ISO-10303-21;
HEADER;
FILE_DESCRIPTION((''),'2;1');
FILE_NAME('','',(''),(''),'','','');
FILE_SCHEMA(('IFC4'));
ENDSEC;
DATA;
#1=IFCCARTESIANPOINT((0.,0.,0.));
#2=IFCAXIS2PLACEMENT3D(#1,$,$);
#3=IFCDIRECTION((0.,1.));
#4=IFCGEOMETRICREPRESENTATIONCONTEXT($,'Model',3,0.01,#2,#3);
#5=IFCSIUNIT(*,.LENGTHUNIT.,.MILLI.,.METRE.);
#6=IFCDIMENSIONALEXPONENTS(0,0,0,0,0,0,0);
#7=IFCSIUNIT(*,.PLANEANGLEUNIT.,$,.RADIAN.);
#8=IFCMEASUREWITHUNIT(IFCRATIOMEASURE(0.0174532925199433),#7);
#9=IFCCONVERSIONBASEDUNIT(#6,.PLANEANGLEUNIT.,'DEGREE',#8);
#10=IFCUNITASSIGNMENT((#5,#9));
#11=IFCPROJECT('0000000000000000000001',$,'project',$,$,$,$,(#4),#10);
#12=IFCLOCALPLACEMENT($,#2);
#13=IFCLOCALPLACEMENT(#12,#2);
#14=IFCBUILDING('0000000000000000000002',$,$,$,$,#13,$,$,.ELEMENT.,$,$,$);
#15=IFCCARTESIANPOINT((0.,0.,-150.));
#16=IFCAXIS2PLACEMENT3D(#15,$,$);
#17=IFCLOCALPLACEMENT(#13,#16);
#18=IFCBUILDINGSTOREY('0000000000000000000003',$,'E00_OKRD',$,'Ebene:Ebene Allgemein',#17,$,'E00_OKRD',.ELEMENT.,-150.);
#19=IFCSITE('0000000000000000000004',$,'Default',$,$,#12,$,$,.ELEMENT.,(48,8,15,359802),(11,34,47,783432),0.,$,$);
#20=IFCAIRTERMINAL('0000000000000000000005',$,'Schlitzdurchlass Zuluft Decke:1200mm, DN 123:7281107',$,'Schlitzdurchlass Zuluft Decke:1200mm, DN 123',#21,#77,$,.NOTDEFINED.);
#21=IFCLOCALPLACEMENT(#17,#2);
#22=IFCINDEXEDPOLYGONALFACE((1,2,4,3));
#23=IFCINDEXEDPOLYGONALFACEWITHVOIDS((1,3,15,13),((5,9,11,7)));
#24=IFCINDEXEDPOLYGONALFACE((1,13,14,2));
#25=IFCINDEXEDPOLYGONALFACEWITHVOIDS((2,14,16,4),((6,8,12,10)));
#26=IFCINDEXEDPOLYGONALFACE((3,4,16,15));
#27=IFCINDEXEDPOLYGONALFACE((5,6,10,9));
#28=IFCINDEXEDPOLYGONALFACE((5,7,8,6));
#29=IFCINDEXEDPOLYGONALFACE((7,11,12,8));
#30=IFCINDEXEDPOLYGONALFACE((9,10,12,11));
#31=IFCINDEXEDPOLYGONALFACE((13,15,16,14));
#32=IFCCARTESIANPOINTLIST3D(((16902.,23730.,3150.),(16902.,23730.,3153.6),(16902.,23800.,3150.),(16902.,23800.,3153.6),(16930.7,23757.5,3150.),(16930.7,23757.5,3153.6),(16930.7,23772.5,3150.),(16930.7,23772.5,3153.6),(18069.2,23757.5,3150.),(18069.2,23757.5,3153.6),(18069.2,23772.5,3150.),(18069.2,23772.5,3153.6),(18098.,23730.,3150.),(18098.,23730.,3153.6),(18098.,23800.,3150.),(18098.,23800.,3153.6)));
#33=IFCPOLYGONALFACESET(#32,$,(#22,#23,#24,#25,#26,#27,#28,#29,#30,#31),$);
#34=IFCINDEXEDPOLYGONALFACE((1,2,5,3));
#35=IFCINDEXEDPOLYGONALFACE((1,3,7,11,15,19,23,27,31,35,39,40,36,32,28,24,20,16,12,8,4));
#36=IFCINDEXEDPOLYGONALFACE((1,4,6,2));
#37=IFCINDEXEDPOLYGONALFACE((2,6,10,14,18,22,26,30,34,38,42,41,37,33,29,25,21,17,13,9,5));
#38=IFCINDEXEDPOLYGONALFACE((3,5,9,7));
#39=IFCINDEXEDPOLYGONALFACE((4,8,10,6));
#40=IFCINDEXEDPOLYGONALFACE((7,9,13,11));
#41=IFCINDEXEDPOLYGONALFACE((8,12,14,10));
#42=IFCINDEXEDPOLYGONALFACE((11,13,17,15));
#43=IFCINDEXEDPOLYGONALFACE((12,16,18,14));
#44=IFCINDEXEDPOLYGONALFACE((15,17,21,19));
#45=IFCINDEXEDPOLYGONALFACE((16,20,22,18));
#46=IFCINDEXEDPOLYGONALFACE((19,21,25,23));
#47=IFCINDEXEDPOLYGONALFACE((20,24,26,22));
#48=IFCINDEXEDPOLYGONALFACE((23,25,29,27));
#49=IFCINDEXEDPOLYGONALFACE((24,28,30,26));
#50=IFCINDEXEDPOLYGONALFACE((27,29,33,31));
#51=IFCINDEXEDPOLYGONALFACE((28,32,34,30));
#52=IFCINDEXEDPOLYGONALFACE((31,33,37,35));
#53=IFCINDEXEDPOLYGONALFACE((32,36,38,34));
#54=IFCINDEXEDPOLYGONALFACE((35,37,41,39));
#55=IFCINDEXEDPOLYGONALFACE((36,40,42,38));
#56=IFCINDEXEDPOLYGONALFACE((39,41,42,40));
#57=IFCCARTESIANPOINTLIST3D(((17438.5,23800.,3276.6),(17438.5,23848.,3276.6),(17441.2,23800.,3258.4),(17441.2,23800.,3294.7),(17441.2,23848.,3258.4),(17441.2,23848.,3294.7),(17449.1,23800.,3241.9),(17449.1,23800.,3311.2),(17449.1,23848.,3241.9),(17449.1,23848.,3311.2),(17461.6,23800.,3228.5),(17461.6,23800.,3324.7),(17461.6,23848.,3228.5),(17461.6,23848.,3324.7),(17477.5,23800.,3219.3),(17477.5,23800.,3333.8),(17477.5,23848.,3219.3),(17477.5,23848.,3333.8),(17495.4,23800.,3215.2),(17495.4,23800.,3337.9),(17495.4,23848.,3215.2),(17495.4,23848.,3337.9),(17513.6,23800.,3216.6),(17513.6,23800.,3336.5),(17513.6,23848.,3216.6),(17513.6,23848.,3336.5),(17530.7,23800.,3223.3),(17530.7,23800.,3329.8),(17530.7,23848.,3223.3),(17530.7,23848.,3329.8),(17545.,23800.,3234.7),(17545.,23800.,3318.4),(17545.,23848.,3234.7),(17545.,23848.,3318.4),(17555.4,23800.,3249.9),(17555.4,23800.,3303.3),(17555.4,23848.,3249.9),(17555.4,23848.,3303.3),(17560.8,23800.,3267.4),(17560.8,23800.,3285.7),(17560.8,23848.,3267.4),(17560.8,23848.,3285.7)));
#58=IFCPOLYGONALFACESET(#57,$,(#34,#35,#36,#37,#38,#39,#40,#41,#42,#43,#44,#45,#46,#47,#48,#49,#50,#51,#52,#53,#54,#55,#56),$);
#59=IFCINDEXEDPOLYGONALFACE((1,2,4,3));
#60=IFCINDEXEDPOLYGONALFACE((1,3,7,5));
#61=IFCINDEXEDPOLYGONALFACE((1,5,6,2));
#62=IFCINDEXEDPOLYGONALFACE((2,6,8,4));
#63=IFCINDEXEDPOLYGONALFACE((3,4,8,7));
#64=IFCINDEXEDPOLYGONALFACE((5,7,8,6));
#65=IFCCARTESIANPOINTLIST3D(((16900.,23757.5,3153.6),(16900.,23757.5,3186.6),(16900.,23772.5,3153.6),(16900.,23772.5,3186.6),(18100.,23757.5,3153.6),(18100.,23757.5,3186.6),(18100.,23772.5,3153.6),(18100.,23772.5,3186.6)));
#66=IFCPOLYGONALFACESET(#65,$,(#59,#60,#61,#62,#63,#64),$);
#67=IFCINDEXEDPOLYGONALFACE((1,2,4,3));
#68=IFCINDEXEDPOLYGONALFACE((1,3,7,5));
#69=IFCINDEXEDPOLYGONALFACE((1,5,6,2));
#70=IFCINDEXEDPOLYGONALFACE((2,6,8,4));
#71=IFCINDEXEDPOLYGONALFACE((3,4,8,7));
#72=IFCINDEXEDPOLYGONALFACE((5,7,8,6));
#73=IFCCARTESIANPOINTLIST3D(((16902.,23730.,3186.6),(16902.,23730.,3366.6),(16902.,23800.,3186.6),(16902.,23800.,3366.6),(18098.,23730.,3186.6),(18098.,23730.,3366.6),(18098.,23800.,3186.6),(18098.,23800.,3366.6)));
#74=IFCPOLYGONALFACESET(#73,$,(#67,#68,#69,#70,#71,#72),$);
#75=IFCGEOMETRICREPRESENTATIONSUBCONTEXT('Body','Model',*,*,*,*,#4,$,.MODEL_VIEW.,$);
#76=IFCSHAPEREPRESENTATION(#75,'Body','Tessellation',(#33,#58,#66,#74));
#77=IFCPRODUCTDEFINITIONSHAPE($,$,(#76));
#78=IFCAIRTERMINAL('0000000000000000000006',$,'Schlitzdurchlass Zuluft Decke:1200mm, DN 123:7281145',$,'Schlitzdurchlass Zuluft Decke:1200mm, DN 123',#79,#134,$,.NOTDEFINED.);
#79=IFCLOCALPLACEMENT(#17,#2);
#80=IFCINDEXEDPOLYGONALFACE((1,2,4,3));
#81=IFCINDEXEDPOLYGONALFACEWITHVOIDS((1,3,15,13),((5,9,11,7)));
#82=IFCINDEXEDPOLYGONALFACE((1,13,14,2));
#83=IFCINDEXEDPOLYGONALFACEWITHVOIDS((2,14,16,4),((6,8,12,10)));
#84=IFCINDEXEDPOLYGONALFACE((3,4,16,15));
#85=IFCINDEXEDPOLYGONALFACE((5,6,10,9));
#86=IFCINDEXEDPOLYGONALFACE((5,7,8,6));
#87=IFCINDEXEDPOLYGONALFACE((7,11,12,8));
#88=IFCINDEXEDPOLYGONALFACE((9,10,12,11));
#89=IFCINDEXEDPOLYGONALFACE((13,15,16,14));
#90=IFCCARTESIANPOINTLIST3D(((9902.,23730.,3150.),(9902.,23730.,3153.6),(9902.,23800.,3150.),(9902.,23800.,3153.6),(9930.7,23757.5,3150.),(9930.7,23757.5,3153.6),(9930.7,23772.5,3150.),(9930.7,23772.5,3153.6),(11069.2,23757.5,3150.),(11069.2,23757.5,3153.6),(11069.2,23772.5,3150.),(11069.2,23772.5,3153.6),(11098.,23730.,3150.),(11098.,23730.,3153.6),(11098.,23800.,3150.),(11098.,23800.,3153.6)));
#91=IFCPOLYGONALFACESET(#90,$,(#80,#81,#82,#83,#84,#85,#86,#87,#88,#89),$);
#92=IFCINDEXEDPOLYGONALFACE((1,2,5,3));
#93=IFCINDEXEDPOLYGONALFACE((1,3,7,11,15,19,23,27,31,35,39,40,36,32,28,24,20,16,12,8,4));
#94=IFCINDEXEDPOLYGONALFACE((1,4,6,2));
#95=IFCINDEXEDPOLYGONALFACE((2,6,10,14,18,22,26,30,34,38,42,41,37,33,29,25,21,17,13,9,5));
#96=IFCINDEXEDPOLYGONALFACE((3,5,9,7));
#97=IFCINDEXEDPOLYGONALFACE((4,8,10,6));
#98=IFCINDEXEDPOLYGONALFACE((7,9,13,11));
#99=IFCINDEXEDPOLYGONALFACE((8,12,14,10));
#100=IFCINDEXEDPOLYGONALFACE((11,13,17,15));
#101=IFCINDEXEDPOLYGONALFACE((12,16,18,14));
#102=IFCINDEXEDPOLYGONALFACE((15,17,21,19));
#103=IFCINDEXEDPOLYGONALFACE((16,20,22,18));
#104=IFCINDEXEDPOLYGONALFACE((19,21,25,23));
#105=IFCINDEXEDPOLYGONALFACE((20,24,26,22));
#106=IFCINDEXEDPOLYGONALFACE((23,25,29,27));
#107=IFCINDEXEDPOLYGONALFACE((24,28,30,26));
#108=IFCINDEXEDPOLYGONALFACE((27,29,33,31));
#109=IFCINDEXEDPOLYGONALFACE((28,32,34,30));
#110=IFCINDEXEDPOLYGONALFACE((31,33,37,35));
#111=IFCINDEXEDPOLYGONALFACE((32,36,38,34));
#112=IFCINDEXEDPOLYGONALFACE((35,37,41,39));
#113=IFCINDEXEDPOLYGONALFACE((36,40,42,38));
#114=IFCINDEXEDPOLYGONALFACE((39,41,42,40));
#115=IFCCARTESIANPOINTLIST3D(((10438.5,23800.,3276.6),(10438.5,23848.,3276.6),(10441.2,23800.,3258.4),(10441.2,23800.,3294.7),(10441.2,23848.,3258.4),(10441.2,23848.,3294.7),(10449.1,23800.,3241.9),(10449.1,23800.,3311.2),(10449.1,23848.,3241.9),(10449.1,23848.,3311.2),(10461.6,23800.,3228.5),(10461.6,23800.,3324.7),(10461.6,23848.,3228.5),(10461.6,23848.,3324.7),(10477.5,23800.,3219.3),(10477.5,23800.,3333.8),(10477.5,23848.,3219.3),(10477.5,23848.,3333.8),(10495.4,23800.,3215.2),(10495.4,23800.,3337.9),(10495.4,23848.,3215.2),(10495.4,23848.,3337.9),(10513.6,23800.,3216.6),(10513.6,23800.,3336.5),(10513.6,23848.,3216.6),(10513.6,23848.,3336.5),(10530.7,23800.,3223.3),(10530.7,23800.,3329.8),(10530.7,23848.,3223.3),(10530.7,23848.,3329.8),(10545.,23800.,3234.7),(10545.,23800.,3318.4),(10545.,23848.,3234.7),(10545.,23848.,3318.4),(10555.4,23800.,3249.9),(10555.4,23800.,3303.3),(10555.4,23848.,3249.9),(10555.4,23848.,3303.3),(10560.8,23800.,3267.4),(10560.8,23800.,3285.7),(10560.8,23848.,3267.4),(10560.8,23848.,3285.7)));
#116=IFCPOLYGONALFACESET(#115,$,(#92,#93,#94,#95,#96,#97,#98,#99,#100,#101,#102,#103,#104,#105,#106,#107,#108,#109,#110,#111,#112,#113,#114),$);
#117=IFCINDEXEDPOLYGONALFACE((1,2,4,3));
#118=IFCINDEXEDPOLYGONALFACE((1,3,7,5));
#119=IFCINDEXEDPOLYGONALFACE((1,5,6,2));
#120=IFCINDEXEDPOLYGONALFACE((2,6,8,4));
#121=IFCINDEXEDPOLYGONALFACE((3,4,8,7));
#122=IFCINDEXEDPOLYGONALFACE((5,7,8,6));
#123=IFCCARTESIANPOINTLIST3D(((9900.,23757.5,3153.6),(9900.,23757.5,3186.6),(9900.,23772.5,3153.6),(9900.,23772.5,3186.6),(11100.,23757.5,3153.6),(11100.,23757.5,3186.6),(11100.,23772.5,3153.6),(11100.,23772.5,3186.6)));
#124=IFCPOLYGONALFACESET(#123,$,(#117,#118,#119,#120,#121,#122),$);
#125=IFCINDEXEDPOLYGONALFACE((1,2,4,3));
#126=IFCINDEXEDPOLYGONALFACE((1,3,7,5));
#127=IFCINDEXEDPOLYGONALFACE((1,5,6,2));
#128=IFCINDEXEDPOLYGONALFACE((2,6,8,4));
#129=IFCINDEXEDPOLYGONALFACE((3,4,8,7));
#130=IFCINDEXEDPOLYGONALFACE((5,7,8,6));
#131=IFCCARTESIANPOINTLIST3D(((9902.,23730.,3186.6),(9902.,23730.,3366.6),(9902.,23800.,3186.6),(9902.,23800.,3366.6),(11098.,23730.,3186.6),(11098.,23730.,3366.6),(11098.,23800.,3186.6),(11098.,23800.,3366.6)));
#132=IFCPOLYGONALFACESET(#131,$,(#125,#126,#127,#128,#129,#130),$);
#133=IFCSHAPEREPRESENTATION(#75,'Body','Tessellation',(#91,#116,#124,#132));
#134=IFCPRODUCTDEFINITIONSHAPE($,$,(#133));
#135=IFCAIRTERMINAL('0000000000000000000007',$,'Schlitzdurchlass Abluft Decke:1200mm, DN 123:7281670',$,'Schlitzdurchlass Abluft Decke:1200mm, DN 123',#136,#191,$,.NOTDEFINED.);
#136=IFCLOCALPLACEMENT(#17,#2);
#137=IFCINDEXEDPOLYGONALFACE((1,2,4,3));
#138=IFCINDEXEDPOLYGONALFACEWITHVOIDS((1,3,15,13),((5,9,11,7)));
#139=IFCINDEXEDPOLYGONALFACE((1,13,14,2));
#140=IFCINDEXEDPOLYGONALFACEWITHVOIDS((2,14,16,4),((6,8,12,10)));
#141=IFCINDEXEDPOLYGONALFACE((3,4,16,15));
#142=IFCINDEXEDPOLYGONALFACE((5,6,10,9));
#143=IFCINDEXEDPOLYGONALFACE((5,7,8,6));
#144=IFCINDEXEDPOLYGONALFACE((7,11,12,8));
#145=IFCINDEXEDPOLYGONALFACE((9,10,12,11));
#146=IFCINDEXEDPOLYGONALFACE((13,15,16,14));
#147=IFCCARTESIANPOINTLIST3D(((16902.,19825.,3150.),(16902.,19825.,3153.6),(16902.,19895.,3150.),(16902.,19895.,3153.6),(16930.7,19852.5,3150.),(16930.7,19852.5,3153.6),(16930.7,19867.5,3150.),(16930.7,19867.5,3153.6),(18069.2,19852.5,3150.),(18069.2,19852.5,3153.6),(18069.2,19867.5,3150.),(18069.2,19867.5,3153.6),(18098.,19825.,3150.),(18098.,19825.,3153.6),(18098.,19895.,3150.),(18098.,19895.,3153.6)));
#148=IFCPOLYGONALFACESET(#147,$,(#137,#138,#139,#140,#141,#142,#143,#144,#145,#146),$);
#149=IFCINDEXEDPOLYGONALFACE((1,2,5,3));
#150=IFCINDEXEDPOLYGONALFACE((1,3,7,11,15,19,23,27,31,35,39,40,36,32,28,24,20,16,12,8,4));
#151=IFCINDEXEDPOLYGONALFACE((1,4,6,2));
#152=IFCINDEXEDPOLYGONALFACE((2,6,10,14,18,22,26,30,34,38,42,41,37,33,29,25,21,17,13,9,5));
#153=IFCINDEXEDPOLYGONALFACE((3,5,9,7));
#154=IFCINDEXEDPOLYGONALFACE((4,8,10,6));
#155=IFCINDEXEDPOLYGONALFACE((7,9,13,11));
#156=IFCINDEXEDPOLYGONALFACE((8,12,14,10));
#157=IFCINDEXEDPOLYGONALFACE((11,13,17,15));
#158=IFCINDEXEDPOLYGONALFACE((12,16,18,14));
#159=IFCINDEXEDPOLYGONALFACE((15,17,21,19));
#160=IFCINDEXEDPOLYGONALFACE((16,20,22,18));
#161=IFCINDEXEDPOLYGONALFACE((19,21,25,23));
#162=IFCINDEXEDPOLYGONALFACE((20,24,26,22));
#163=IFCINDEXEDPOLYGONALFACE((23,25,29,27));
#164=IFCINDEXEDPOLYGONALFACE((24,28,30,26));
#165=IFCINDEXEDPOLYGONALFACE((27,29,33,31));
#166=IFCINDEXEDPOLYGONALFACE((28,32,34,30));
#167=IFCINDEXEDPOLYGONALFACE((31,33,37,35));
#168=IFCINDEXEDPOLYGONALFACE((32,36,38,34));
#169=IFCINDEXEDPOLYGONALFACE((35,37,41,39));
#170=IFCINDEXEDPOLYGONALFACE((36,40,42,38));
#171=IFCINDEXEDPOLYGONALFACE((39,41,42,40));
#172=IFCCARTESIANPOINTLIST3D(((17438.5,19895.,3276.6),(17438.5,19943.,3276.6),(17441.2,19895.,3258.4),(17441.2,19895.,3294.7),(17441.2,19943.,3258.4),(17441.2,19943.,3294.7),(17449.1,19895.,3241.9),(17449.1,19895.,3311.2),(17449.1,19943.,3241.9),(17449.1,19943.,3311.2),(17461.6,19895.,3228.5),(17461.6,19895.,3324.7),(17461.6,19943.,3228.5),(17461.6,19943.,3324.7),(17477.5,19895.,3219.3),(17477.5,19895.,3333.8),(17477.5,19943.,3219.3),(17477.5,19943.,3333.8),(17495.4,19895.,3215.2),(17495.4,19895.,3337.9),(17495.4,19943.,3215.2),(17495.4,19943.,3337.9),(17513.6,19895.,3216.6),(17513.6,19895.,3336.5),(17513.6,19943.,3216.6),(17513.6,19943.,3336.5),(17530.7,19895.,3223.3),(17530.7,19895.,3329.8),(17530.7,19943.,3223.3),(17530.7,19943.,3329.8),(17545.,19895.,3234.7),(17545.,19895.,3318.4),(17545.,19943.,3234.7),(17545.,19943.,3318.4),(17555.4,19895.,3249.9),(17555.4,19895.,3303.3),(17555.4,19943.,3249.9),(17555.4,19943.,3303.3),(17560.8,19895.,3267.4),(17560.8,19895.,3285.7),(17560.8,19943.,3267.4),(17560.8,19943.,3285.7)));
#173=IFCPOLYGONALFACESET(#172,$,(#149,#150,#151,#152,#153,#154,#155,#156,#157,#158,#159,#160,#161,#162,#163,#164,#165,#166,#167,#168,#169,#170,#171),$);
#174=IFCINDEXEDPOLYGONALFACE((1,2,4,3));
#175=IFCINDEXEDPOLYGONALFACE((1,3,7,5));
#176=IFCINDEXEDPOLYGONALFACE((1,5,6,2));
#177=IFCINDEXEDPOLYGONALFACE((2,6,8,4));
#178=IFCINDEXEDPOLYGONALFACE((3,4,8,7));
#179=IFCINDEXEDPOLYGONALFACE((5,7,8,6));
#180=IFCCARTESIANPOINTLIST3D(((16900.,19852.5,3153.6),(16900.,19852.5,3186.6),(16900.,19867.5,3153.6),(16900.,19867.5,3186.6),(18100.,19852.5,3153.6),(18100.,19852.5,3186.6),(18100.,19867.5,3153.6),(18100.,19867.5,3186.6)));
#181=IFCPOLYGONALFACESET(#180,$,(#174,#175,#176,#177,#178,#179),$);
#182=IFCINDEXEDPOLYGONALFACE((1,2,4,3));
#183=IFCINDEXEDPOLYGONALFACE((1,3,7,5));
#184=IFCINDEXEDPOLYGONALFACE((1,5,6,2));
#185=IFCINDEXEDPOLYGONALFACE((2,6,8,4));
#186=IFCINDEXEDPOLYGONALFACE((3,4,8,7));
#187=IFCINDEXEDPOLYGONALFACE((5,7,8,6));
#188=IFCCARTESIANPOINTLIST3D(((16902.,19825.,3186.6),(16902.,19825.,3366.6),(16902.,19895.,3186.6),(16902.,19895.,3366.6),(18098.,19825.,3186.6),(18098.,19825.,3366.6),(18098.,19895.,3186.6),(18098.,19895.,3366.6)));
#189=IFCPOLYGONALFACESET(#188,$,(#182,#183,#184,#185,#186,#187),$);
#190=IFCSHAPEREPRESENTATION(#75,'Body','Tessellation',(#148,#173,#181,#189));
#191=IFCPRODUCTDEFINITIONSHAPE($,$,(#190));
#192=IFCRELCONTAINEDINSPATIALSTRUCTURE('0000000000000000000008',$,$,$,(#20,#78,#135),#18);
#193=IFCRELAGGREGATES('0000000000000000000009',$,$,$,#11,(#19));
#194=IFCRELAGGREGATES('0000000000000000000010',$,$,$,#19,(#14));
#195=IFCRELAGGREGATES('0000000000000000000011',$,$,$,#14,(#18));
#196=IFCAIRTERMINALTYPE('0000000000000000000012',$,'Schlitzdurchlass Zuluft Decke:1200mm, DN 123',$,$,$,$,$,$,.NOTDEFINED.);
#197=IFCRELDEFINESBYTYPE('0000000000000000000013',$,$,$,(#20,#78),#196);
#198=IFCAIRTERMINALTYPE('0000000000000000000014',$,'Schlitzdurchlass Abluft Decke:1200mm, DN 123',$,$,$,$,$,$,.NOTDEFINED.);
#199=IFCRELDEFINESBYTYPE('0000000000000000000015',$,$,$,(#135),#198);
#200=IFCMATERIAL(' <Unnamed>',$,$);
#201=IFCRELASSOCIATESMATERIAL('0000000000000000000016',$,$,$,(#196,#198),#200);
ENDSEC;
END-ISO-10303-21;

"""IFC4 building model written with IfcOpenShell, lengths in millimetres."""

from ifc_helpers import new_model, entity, si_unit, converted_unit, direction, frame, frame_2d, origin, origin_2d_with_axis, place, context, subcontext, project, spatial, polyline, rectangle, circle, outline, extrude, source, transform, mapped, material, type_object, type_shapes, element, save


model = new_model("IFC4")

# Units and contexts
model_context = context("Model", 3, precision=0.01, world=origin(), true_north=direction((0.0, 1.0)))
body_context = subcontext(model_context, "Body", "Model", "MODEL_VIEW")
ifc_project = project(units=[si_unit("LENGTHUNIT", "METRE", prefix="MILLI"), converted_unit("PLANEANGLEUNIT", "DEGREE", entity("IfcRatioMeasure", 0.0174532925199433), si_unit("PLANEANGLEUNIT", "RADIAN"), dimensions=[0, 0, 0, 0, 0, 0, 0])], contexts=[model_context])

# Site, building, storey
site_placement = place(None, origin())
site = spatial("IfcSite", under=ifc_project, at=site_placement, Name="Default", CompositionType="ELEMENT", RefLatitude=(48, 8, 15, 359802), RefLongitude=(11, 34, 47, 783432), RefElevation=0.0)
building_placement = place(site_placement, origin())
building = spatial("IfcBuilding", under=site, at=building_placement, CompositionType="ELEMENT")
storey_placement = place(building_placement, frame((0.0, 0.0, -150.0)))
storey = spatial("IfcBuildingStorey", under=building, at=storey_placement, Name="E00_OKRD", ObjectType="Ebene:Ebene Allgemein", LongName="E00_OKRD", CompositionType="ELEMENT", Elevation=-150.0)

# Air terminals
ifc_material_1 = material(Name=" <Unnamed>")
air_terminal_type_1 = type_object("IfcAirTerminalType", Name="Schlitzdurchlass Zuluft Decke:1200mm, DN 123", PredefinedType="NOTDEFINED", material=ifc_material_1)
shared_shape_1 = source(origin(), body_context, "Body", "SweptSolid", [
    extrude(outline(polyline([(-598.0, -35.0), (598.0, -35.0), (598.0, 35.0), (-598.0, 35.0), (-598.0, -35.0)]), holes=[polyline([(-569.2, -7.5), (-569.2, 7.5), (569.2, 7.5), (569.2, -7.5), (-569.2, -7.5)])]), frame((600.0, 35.0, 0.0), z_axis=(0.0, 0.0, 1.0), x_axis=(-1.0, 0.0, 0.0)), (0.0, 0.0, 1.0), 3.6),
    extrude(circle(Radius=61.5, at=frame_2d((0.0, 0.0), x_axis=(1.0, 0.0))), frame((600.0, 70.0, 126.6), z_axis=(0.0, 1.0, 0.0), x_axis=(-1.0, 0.0, 0.0)), (0.0, 0.0, 1.0), 48.0),
    extrude(rectangle(XDim=1200.0, YDim=15.0, at=origin_2d_with_axis()), frame((600.0, 35.0, 3.6), z_axis=(0.0, 0.0, 1.0), x_axis=(-1.0, 0.0, 0.0)), (0.0, 0.0, 1.0), 33.0),
    extrude(rectangle(XDim=1196.0, YDim=70.0, at=origin_2d_with_axis()), frame((600.0, 35.0, 36.6), z_axis=(0.0, 0.0, 1.0), x_axis=(-1.0, 0.0, 0.0)), (0.0, 0.0, 1.0), 180.0),
])
type_shapes(air_terminal_type_1, [shared_shape_1])
for number, where, name in (
    (1, (16900.0, 23730.0, 3150.0), "Schlitzdurchlass Zuluft Decke:1200mm, DN 123:7281107"),
    (2, (9900.0, 23730.0, 3150.0), "Schlitzdurchlass Zuluft Decke:1200mm, DN 123:7281145"),
):
    element("IfcAirTerminal", number, at=place(storey_placement, frame(where)), inside=storey, type_object=air_terminal_type_1, Name=name, ObjectType="Schlitzdurchlass Zuluft Decke:1200mm, DN 123", PredefinedType="NOTDEFINED", context=body_context, shape_type="MappedRepresentation", body=[
        mapped(shared_shape_1, transform((0.0, 0.0, 0.0), scale=1.0)),
    ])
air_terminal_type_2 = type_object("IfcAirTerminalType", Name="Schlitzdurchlass Abluft Decke:1200mm, DN 123", PredefinedType="NOTDEFINED", material=ifc_material_1)
shared_shape_2 = source(origin(), body_context, "Body", "SweptSolid", [
    extrude(outline(polyline([(-598.0, -35.0), (598.0, -35.0), (598.0, 35.0), (-598.0, 35.0), (-598.0, -35.0)]), holes=[polyline([(-569.2, -7.5), (-569.2, 7.5), (569.2, 7.5), (569.2, -7.5), (-569.2, -7.5)])]), frame((0.0, 0.0, 0.0), z_axis=(0.0, 0.0, 1.0), x_axis=(-1.0, 0.0, 0.0)), (0.0, 0.0, 1.0), 3.6),
    extrude(circle(Radius=61.5, at=frame_2d((0.0, 0.0), x_axis=(1.0, 0.0))), frame((0.0, 35.0, 126.6), z_axis=(0.0, 1.0, 0.0), x_axis=(-1.0, 0.0, 0.0)), (0.0, 0.0, 1.0), 48.0),
    extrude(rectangle(XDim=1200.0, YDim=15.0, at=origin_2d_with_axis()), frame((0.0, 0.0, 3.6), z_axis=(0.0, 0.0, 1.0), x_axis=(-1.0, 0.0, 0.0)), (0.0, 0.0, 1.0), 33.0),
    extrude(rectangle(XDim=1196.0, YDim=70.0, at=origin_2d_with_axis()), frame((0.0, 0.0, 36.6), z_axis=(0.0, 0.0, 1.0), x_axis=(-1.0, 0.0, 0.0)), (0.0, 0.0, 1.0), 180.0),
])
type_shapes(air_terminal_type_2, [shared_shape_2])
for number, where, name in (
    (3, (17500.0, 19860.0, 3150.0), "Schlitzdurchlass Abluft Decke:1200mm, DN 123:7281670"),
):
    element("IfcAirTerminal", number, at=place(storey_placement, frame(where)), inside=storey, type_object=air_terminal_type_2, Name=name, ObjectType="Schlitzdurchlass Abluft Decke:1200mm, DN 123", PredefinedType="NOTDEFINED", context=body_context, shape_type="MappedRepresentation", body=[
        mapped(shared_shape_2, transform((0.0, 0.0, 0.0), scale=1.0)),
    ])

save(model, "model.ifc")
